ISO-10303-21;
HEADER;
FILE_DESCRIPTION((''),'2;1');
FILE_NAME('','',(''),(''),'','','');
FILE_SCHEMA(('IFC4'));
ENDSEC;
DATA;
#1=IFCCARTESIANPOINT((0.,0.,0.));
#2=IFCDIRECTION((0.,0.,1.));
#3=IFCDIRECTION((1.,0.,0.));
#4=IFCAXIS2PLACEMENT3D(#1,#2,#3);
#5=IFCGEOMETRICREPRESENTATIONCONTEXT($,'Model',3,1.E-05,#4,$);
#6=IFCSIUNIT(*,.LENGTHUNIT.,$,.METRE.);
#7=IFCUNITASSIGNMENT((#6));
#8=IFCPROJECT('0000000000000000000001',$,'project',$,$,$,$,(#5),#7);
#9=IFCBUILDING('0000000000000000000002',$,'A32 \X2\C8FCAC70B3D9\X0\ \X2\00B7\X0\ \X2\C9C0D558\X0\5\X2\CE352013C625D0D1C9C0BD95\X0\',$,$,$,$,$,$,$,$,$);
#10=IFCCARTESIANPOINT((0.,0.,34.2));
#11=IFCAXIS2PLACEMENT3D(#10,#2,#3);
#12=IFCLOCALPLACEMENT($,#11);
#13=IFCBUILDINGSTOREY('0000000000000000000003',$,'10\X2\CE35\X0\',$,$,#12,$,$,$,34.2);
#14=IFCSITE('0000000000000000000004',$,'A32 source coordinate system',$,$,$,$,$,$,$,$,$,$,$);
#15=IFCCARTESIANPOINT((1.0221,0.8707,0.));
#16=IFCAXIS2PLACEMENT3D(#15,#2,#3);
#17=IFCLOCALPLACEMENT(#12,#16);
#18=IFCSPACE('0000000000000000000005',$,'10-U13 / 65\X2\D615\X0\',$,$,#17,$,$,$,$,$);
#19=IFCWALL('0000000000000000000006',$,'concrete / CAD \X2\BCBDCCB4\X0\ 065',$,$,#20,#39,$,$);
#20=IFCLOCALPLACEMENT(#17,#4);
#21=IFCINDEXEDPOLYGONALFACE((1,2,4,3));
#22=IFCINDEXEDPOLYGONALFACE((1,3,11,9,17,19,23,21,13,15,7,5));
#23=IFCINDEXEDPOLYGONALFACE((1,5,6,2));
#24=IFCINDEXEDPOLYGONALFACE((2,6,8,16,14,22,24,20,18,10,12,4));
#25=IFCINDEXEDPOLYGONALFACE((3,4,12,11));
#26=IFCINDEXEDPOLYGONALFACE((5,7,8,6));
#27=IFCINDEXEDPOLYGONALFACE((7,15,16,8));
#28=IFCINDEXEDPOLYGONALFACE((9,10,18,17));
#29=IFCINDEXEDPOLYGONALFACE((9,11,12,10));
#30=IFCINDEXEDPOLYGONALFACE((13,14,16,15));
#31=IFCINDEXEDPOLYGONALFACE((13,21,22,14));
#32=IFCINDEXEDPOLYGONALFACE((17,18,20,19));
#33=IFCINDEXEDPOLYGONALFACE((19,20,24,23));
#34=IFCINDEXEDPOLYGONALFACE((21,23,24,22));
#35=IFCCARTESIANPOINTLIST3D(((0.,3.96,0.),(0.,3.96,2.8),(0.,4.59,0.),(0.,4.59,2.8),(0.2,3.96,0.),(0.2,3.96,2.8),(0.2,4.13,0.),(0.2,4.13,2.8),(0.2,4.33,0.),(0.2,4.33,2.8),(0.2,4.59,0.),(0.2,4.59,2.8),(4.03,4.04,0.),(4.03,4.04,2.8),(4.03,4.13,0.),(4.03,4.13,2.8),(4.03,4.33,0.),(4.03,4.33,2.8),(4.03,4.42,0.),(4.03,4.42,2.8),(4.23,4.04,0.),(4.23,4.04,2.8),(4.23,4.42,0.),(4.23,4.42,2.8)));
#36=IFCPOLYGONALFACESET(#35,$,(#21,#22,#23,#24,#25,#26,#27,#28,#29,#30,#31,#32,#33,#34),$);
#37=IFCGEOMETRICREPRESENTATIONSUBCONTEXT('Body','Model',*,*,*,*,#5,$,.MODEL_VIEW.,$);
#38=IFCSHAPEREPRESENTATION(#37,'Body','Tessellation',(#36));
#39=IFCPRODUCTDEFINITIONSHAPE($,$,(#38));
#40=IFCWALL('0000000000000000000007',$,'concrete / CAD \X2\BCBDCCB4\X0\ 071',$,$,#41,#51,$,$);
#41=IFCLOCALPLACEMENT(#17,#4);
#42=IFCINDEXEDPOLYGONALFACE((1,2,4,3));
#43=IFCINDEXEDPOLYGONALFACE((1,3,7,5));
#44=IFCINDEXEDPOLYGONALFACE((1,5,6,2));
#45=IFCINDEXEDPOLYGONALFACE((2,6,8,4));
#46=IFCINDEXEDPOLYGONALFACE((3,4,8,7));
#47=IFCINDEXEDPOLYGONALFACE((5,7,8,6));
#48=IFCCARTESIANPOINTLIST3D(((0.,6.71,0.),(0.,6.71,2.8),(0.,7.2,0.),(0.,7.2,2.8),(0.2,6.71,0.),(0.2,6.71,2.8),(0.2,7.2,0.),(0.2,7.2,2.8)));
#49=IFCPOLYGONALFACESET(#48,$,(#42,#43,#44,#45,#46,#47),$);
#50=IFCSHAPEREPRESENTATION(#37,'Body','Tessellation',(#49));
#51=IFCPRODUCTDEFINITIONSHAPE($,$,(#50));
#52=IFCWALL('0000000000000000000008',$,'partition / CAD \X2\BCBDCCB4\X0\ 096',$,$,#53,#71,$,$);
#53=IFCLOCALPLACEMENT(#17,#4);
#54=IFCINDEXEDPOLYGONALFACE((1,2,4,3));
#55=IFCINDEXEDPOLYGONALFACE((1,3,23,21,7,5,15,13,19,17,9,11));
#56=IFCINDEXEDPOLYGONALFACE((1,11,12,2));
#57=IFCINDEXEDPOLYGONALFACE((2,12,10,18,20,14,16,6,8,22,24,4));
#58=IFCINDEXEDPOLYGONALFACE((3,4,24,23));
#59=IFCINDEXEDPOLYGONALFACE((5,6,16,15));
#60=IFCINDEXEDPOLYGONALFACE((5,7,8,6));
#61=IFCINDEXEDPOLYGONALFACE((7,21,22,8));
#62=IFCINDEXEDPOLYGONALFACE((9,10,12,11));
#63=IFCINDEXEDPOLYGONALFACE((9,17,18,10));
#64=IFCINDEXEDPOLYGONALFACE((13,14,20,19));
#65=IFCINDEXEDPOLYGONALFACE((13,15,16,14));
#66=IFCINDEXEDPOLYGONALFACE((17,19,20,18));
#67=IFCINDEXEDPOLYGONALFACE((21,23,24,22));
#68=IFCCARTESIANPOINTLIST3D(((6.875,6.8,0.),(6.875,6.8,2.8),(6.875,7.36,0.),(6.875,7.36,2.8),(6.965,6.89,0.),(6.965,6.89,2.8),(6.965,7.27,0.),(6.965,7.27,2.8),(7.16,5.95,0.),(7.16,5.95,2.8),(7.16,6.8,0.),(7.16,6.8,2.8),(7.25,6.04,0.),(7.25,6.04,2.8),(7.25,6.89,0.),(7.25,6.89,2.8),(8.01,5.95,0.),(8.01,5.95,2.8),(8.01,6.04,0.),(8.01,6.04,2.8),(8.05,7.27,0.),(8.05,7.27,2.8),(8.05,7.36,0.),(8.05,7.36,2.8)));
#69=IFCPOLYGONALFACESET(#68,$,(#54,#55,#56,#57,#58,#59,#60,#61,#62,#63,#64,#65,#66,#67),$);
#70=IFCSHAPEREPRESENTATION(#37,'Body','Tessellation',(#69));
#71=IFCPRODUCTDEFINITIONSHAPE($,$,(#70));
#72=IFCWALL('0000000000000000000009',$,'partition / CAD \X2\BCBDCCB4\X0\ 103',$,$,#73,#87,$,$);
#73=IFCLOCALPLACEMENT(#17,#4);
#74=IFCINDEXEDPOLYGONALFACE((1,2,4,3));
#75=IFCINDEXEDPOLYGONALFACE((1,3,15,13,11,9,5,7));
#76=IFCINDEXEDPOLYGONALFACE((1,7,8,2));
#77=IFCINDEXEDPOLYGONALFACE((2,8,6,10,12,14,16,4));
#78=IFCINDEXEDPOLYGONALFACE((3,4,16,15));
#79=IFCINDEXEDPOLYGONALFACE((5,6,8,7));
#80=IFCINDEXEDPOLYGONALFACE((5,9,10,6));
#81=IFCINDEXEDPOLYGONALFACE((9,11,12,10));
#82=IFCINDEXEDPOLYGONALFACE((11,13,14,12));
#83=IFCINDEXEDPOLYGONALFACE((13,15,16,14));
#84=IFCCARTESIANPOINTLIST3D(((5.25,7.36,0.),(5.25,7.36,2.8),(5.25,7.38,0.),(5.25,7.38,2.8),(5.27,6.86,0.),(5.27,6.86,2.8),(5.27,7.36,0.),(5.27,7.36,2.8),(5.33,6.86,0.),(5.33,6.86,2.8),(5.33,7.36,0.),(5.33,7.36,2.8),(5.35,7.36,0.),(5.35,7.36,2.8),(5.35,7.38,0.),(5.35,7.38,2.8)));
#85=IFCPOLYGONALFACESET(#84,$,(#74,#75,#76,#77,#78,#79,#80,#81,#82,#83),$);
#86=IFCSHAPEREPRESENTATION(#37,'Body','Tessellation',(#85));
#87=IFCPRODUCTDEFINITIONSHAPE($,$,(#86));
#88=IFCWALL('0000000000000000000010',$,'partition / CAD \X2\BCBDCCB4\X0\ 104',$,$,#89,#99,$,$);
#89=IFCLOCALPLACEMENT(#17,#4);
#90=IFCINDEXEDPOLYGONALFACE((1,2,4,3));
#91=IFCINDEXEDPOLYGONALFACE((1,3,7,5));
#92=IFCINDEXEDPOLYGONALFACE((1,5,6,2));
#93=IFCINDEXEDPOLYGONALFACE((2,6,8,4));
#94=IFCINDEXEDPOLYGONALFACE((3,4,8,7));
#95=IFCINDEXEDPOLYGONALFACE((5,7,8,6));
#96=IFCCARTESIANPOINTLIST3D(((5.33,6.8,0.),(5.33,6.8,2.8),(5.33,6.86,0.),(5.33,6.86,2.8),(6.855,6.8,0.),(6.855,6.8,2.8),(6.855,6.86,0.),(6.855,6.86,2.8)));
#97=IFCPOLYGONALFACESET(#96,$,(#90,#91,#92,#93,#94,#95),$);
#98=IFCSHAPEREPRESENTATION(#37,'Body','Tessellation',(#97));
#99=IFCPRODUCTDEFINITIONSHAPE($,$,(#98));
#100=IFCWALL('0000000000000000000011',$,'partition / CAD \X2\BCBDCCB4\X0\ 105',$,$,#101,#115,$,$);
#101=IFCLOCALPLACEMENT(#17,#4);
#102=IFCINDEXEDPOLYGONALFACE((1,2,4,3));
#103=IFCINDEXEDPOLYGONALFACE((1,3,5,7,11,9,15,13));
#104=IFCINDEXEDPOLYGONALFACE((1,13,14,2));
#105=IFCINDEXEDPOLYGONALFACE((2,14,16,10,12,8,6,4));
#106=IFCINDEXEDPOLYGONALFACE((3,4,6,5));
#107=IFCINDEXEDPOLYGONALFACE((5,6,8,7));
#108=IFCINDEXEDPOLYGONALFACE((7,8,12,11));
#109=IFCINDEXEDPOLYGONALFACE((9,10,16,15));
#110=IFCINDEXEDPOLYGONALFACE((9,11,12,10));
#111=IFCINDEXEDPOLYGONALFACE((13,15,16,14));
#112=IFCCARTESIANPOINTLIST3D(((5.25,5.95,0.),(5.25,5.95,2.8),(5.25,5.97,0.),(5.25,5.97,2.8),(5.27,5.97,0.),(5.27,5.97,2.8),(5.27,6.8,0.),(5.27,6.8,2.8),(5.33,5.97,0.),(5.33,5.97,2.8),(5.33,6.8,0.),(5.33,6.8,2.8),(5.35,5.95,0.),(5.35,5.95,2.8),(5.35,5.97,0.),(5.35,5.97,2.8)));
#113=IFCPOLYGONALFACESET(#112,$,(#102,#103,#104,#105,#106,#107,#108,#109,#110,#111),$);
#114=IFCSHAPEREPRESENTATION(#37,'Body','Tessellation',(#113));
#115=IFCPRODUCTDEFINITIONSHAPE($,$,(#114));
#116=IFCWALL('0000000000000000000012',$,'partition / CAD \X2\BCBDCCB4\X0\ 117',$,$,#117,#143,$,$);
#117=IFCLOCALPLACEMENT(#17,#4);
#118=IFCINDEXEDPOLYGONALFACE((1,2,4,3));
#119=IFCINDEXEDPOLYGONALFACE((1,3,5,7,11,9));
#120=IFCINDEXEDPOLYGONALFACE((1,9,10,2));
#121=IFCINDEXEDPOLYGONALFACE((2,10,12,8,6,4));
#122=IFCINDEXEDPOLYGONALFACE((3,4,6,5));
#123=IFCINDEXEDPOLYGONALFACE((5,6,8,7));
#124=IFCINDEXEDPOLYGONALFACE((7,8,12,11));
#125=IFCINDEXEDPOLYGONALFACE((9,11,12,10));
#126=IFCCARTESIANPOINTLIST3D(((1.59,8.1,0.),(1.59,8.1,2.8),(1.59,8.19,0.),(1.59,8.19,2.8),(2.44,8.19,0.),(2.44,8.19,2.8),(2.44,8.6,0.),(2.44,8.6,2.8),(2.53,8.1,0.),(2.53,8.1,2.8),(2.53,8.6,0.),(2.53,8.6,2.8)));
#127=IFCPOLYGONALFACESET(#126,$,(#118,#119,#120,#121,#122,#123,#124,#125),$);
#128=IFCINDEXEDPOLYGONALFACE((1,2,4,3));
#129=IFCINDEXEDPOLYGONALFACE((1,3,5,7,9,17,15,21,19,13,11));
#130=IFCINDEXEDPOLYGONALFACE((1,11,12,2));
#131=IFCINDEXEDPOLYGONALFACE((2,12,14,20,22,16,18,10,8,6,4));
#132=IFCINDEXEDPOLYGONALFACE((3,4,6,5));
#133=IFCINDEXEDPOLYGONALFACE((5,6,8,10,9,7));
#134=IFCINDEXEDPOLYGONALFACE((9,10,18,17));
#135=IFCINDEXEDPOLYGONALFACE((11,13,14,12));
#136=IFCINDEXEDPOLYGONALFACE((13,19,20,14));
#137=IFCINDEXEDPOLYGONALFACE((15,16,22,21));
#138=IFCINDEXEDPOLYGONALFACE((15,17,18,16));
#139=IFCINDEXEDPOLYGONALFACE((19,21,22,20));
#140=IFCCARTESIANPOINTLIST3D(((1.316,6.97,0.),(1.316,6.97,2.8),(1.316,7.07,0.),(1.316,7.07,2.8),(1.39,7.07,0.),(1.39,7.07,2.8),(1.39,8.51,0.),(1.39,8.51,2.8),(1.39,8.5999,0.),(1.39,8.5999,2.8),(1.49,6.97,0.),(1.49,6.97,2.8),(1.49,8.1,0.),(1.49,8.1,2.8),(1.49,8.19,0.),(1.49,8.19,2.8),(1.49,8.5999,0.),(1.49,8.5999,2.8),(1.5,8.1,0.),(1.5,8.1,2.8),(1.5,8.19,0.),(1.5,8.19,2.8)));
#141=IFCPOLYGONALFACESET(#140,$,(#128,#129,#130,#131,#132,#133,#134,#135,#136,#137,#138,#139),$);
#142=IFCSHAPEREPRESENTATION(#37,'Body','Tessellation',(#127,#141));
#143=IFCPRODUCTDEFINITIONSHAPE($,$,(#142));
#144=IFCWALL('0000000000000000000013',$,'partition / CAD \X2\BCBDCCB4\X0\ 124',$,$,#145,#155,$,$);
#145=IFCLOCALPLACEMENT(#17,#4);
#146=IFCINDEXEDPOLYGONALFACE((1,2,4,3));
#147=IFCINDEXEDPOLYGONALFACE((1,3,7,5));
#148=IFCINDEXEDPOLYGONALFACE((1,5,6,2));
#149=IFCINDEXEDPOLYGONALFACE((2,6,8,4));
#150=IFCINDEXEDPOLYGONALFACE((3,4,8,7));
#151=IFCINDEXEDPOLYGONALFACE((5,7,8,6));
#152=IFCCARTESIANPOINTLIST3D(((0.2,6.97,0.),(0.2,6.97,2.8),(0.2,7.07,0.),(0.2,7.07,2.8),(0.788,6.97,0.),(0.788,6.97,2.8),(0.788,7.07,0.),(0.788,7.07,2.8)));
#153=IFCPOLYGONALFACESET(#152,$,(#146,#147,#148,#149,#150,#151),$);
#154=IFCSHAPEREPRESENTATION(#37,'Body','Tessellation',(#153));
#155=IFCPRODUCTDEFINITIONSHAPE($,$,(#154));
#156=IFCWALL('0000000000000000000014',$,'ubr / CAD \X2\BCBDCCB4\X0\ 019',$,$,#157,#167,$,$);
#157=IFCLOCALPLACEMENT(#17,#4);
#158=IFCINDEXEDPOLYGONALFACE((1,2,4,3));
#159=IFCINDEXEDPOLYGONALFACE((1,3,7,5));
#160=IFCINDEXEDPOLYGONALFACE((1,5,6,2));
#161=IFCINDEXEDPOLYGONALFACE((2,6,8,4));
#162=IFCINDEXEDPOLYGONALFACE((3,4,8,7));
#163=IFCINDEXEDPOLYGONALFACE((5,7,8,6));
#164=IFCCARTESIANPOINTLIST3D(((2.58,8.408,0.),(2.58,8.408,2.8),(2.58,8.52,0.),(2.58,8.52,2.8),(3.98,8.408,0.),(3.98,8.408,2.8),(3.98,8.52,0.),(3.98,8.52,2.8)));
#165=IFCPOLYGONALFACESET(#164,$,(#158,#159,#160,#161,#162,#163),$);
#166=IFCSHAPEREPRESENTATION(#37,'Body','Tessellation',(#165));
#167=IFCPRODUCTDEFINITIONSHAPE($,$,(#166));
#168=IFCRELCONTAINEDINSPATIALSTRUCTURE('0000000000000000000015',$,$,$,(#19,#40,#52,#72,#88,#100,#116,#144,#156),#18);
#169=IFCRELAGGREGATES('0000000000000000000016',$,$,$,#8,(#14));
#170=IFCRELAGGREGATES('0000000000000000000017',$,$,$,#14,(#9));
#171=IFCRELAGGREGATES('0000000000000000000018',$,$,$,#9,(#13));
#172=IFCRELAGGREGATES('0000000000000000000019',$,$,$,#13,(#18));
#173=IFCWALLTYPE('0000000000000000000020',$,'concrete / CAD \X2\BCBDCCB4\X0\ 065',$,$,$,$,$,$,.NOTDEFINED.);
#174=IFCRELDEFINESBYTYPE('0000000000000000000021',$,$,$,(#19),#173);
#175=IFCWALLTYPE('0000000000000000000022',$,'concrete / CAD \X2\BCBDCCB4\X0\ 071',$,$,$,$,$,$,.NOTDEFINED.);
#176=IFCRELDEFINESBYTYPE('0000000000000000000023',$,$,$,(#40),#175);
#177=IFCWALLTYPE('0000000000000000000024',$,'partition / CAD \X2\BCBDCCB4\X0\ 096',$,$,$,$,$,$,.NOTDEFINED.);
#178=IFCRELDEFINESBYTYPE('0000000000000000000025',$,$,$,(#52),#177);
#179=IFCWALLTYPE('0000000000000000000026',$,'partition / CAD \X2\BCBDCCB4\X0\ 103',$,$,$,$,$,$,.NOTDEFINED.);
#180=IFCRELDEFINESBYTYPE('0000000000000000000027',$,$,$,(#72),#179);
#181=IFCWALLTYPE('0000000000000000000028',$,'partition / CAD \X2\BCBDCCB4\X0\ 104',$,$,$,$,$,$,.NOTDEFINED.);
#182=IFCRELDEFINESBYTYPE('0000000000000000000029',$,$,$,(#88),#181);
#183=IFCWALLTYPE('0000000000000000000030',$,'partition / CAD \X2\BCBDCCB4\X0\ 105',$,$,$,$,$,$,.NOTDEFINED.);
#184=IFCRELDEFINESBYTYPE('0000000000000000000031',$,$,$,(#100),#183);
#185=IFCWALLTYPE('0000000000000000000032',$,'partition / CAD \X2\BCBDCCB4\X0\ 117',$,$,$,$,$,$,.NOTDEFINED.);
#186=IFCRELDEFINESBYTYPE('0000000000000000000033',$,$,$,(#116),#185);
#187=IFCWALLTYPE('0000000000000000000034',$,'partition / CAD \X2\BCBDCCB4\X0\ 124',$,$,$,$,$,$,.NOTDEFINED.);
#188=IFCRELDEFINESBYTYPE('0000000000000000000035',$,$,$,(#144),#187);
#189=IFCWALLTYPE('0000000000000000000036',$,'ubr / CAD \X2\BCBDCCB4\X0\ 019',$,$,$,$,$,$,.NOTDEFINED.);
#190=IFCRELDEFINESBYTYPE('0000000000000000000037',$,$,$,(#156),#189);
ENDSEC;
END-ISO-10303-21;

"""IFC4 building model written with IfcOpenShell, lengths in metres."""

from ifc_helpers import new_model, si_unit, frame, origin, origin_with_axes, place, context, subcontext, project, spatial, polyline, outline, extrude, source, transform, mapped, type_object, type_shapes, element, save


model = new_model("IFC4")

# Units and contexts
model_context = context("Model", 3, precision=1e-05, world=origin_with_axes())
body_context = subcontext(model_context, "Body", "Model", "MODEL_VIEW")
ifc_project = project(units=[si_unit("LENGTHUNIT", "METRE")], contexts=[model_context])

# Site, building, storey, space
storey_placement = place(None, frame((0.0, 0.0, 34.2), z_axis=(0.0, 0.0, 1.0), x_axis=(1.0, 0.0, 0.0)))
space_placement = place(storey_placement, frame((1.0221, 0.8707, 0.0), z_axis=(0.0, 0.0, 1.0), x_axis=(1.0, 0.0, 0.0)))
site = spatial("IfcSite", under=ifc_project, Name="A32 source coordinate system")
building = spatial("IfcBuilding", under=site, Name="A32 주거동 · 지하5층–옥탑지붕")
storey = spatial("IfcBuildingStorey", under=building, at=storey_placement, Name="10층", Elevation=34.2)
space = spatial("IfcSpace", under=storey, at=space_placement, Name="10-U13 / 65형")

# Walls
wall_type_1 = type_object("IfcWallType", Name="concrete / CAD 벽체 065", PredefinedType="NOTDEFINED")
shared_shape_1 = source(origin(), body_context, "Body", "SweptSolid", [
    extrude(outline(polyline([(0.2, 4.59), (0.2, 4.33), (4.03, 4.33), (4.03, 4.42), (4.23, 4.42), (4.23, 4.04), (4.03, 4.04), (4.03, 4.13), (0.2, 4.13), (0.2, 3.96), (0.0, 3.96), (0.0, 4.59), (0.2, 4.59)])), origin(), (0.0, 0.0, 1.0), 2.8),
])
type_shapes(wall_type_1, [shared_shape_1])
wall_1_placement = place(space_placement, origin_with_axes())
element("IfcWall", 1, at=wall_1_placement, inside=space, type_object=wall_type_1, Name="concrete / CAD 벽체 065", context=body_context, shape_type="MappedRepresentation", body=[
    mapped(shared_shape_1, transform((0.0, 0.0, 0.0), scale=1.0)),
])
wall_type_2 = type_object("IfcWallType", Name="concrete / CAD 벽체 071", PredefinedType="NOTDEFINED")
shared_shape_2 = source(origin(), body_context, "Body", "SweptSolid", [
    extrude(outline(polyline([(0.2, 6.71), (0.0, 6.71), (0.0, 7.2), (0.2, 7.2), (0.2, 6.71)])), origin(), (0.0, 0.0, 1.0), 2.8),
])
type_shapes(wall_type_2, [shared_shape_2])
wall_2_placement = place(space_placement, origin_with_axes())
element("IfcWall", 2, at=wall_2_placement, inside=space, type_object=wall_type_2, Name="concrete / CAD 벽체 071", context=body_context, shape_type="MappedRepresentation", body=[
    mapped(shared_shape_2, transform((0.0, 0.0, 0.0), scale=1.0)),
])
wall_type_3 = type_object("IfcWallType", Name="partition / CAD 벽체 096", PredefinedType="NOTDEFINED")
shared_shape_3 = source(origin(), body_context, "Body", "SweptSolid", [
    extrude(outline(polyline([(7.25, 6.04), (8.01, 6.04), (8.01, 5.95), (7.16, 5.95), (7.16, 6.8), (6.875, 6.8), (6.875, 7.36), (8.05, 7.36), (8.05, 7.27), (6.965, 7.27), (6.965, 6.89), (7.25, 6.89), (7.25, 6.04)])), origin(), (0.0, 0.0, 1.0), 2.8),
])
type_shapes(wall_type_3, [shared_shape_3])
wall_3_placement = place(space_placement, origin_with_axes())
element("IfcWall", 3, at=wall_3_placement, inside=space, type_object=wall_type_3, Name="partition / CAD 벽체 096", context=body_context, shape_type="MappedRepresentation", body=[
    mapped(shared_shape_3, transform((0.0, 0.0, 0.0), scale=1.0)),
])
wall_type_4 = type_object("IfcWallType", Name="partition / CAD 벽체 103", PredefinedType="NOTDEFINED")
shared_shape_4 = source(origin(), body_context, "Body", "SweptSolid", [
    extrude(outline(polyline([(5.27, 7.36), (5.25, 7.36), (5.25, 7.38), (5.35, 7.38), (5.35, 7.36), (5.33, 7.36), (5.33, 6.86), (5.27, 6.86), (5.27, 7.36)])), origin(), (0.0, 0.0, 1.0), 2.8),
])
type_shapes(wall_type_4, [shared_shape_4])
wall_4_placement = place(space_placement, origin_with_axes())
element("IfcWall", 4, at=wall_4_placement, inside=space, type_object=wall_type_4, Name="partition / CAD 벽체 103", context=body_context, shape_type="MappedRepresentation", body=[
    mapped(shared_shape_4, transform((0.0, 0.0, 0.0), scale=1.0)),
])
wall_type_5 = type_object("IfcWallType", Name="partition / CAD 벽체 104", PredefinedType="NOTDEFINED")
shared_shape_5 = source(origin(), body_context, "Body", "SweptSolid", [
    extrude(outline(polyline([(6.855, 6.86), (6.855, 6.8), (5.33, 6.8), (5.33, 6.86), (6.855, 6.86)])), origin(), (0.0, 0.0, 1.0), 2.8),
])
type_shapes(wall_type_5, [shared_shape_5])
wall_5_placement = place(space_placement, origin_with_axes())
element("IfcWall", 5, at=wall_5_placement, inside=space, type_object=wall_type_5, Name="partition / CAD 벽체 104", context=body_context, shape_type="MappedRepresentation", body=[
    mapped(shared_shape_5, transform((0.0, 0.0, 0.0), scale=1.0)),
])
wall_type_6 = type_object("IfcWallType", Name="partition / CAD 벽체 105", PredefinedType="NOTDEFINED")
shared_shape_6 = source(origin(), body_context, "Body", "SweptSolid", [
    extrude(outline(polyline([(5.25, 5.97), (5.27, 5.97), (5.27, 6.8), (5.33, 6.8), (5.33, 5.97), (5.35, 5.97), (5.35, 5.95), (5.25, 5.95), (5.25, 5.97)])), origin(), (0.0, 0.0, 1.0), 2.8),
])
type_shapes(wall_type_6, [shared_shape_6])
wall_6_placement = place(space_placement, origin_with_axes())
element("IfcWall", 6, at=wall_6_placement, inside=space, type_object=wall_type_6, Name="partition / CAD 벽체 105", context=body_context, shape_type="MappedRepresentation", body=[
    mapped(shared_shape_6, transform((0.0, 0.0, 0.0), scale=1.0)),
])
wall_type_7 = type_object("IfcWallType", Name="partition / CAD 벽체 117", PredefinedType="NOTDEFINED")
shared_shape_7 = source(origin(), body_context, "Body", "SweptSolid", [
    extrude(outline(polyline([(2.53, 8.1), (1.59, 8.1), (1.59, 8.19), (2.44, 8.19), (2.44, 8.6), (2.53, 8.6), (2.53, 8.1)])), origin(), (0.0, 0.0, 1.0), 2.8),
    extrude(outline(polyline([(1.49, 8.1), (1.49, 6.97), (1.316, 6.97), (1.316, 7.07), (1.39, 7.07), (1.39, 8.51), (1.39, 8.5999), (1.49, 8.5999), (1.49, 8.19), (1.5, 8.19), (1.5, 8.1), (1.49, 8.1)])), origin(), (0.0, 0.0, 1.0), 2.8),
])
type_shapes(wall_type_7, [shared_shape_7])
wall_7_placement = place(space_placement, origin_with_axes())
element("IfcWall", 7, at=wall_7_placement, inside=space, type_object=wall_type_7, Name="partition / CAD 벽체 117", context=body_context, shape_type="MappedRepresentation", body=[
    mapped(shared_shape_7, transform((0.0, 0.0, 0.0), scale=1.0)),
])
wall_type_8 = type_object("IfcWallType", Name="partition / CAD 벽체 124", PredefinedType="NOTDEFINED")
shared_shape_8 = source(origin(), body_context, "Body", "SweptSolid", [
    extrude(outline(polyline([(0.788, 7.07), (0.788, 6.97), (0.2, 6.97), (0.2, 7.07), (0.788, 7.07)])), origin(), (0.0, 0.0, 1.0), 2.8),
])
type_shapes(wall_type_8, [shared_shape_8])
wall_8_placement = place(space_placement, origin_with_axes())
element("IfcWall", 8, at=wall_8_placement, inside=space, type_object=wall_type_8, Name="partition / CAD 벽체 124", context=body_context, shape_type="MappedRepresentation", body=[
    mapped(shared_shape_8, transform((0.0, 0.0, 0.0), scale=1.0)),
])
wall_type_9 = type_object("IfcWallType", Name="ubr / CAD 벽체 019", PredefinedType="NOTDEFINED")
shared_shape_9 = source(origin(), body_context, "Body", "SweptSolid", [
    extrude(outline(polyline([(3.98, 8.408), (2.58, 8.408), (2.58, 8.52), (3.98, 8.52), (3.98, 8.408)])), origin(), (0.0, 0.0, 1.0), 2.8),
])
type_shapes(wall_type_9, [shared_shape_9])
wall_9_placement = place(space_placement, origin_with_axes())
element("IfcWall", 9, at=wall_9_placement, inside=space, type_object=wall_type_9, Name="ubr / CAD 벽체 019", context=body_context, shape_type="MappedRepresentation", body=[
    mapped(shared_shape_9, transform((0.0, 0.0, 0.0), scale=1.0)),
])

save(model, "model.ifc")
